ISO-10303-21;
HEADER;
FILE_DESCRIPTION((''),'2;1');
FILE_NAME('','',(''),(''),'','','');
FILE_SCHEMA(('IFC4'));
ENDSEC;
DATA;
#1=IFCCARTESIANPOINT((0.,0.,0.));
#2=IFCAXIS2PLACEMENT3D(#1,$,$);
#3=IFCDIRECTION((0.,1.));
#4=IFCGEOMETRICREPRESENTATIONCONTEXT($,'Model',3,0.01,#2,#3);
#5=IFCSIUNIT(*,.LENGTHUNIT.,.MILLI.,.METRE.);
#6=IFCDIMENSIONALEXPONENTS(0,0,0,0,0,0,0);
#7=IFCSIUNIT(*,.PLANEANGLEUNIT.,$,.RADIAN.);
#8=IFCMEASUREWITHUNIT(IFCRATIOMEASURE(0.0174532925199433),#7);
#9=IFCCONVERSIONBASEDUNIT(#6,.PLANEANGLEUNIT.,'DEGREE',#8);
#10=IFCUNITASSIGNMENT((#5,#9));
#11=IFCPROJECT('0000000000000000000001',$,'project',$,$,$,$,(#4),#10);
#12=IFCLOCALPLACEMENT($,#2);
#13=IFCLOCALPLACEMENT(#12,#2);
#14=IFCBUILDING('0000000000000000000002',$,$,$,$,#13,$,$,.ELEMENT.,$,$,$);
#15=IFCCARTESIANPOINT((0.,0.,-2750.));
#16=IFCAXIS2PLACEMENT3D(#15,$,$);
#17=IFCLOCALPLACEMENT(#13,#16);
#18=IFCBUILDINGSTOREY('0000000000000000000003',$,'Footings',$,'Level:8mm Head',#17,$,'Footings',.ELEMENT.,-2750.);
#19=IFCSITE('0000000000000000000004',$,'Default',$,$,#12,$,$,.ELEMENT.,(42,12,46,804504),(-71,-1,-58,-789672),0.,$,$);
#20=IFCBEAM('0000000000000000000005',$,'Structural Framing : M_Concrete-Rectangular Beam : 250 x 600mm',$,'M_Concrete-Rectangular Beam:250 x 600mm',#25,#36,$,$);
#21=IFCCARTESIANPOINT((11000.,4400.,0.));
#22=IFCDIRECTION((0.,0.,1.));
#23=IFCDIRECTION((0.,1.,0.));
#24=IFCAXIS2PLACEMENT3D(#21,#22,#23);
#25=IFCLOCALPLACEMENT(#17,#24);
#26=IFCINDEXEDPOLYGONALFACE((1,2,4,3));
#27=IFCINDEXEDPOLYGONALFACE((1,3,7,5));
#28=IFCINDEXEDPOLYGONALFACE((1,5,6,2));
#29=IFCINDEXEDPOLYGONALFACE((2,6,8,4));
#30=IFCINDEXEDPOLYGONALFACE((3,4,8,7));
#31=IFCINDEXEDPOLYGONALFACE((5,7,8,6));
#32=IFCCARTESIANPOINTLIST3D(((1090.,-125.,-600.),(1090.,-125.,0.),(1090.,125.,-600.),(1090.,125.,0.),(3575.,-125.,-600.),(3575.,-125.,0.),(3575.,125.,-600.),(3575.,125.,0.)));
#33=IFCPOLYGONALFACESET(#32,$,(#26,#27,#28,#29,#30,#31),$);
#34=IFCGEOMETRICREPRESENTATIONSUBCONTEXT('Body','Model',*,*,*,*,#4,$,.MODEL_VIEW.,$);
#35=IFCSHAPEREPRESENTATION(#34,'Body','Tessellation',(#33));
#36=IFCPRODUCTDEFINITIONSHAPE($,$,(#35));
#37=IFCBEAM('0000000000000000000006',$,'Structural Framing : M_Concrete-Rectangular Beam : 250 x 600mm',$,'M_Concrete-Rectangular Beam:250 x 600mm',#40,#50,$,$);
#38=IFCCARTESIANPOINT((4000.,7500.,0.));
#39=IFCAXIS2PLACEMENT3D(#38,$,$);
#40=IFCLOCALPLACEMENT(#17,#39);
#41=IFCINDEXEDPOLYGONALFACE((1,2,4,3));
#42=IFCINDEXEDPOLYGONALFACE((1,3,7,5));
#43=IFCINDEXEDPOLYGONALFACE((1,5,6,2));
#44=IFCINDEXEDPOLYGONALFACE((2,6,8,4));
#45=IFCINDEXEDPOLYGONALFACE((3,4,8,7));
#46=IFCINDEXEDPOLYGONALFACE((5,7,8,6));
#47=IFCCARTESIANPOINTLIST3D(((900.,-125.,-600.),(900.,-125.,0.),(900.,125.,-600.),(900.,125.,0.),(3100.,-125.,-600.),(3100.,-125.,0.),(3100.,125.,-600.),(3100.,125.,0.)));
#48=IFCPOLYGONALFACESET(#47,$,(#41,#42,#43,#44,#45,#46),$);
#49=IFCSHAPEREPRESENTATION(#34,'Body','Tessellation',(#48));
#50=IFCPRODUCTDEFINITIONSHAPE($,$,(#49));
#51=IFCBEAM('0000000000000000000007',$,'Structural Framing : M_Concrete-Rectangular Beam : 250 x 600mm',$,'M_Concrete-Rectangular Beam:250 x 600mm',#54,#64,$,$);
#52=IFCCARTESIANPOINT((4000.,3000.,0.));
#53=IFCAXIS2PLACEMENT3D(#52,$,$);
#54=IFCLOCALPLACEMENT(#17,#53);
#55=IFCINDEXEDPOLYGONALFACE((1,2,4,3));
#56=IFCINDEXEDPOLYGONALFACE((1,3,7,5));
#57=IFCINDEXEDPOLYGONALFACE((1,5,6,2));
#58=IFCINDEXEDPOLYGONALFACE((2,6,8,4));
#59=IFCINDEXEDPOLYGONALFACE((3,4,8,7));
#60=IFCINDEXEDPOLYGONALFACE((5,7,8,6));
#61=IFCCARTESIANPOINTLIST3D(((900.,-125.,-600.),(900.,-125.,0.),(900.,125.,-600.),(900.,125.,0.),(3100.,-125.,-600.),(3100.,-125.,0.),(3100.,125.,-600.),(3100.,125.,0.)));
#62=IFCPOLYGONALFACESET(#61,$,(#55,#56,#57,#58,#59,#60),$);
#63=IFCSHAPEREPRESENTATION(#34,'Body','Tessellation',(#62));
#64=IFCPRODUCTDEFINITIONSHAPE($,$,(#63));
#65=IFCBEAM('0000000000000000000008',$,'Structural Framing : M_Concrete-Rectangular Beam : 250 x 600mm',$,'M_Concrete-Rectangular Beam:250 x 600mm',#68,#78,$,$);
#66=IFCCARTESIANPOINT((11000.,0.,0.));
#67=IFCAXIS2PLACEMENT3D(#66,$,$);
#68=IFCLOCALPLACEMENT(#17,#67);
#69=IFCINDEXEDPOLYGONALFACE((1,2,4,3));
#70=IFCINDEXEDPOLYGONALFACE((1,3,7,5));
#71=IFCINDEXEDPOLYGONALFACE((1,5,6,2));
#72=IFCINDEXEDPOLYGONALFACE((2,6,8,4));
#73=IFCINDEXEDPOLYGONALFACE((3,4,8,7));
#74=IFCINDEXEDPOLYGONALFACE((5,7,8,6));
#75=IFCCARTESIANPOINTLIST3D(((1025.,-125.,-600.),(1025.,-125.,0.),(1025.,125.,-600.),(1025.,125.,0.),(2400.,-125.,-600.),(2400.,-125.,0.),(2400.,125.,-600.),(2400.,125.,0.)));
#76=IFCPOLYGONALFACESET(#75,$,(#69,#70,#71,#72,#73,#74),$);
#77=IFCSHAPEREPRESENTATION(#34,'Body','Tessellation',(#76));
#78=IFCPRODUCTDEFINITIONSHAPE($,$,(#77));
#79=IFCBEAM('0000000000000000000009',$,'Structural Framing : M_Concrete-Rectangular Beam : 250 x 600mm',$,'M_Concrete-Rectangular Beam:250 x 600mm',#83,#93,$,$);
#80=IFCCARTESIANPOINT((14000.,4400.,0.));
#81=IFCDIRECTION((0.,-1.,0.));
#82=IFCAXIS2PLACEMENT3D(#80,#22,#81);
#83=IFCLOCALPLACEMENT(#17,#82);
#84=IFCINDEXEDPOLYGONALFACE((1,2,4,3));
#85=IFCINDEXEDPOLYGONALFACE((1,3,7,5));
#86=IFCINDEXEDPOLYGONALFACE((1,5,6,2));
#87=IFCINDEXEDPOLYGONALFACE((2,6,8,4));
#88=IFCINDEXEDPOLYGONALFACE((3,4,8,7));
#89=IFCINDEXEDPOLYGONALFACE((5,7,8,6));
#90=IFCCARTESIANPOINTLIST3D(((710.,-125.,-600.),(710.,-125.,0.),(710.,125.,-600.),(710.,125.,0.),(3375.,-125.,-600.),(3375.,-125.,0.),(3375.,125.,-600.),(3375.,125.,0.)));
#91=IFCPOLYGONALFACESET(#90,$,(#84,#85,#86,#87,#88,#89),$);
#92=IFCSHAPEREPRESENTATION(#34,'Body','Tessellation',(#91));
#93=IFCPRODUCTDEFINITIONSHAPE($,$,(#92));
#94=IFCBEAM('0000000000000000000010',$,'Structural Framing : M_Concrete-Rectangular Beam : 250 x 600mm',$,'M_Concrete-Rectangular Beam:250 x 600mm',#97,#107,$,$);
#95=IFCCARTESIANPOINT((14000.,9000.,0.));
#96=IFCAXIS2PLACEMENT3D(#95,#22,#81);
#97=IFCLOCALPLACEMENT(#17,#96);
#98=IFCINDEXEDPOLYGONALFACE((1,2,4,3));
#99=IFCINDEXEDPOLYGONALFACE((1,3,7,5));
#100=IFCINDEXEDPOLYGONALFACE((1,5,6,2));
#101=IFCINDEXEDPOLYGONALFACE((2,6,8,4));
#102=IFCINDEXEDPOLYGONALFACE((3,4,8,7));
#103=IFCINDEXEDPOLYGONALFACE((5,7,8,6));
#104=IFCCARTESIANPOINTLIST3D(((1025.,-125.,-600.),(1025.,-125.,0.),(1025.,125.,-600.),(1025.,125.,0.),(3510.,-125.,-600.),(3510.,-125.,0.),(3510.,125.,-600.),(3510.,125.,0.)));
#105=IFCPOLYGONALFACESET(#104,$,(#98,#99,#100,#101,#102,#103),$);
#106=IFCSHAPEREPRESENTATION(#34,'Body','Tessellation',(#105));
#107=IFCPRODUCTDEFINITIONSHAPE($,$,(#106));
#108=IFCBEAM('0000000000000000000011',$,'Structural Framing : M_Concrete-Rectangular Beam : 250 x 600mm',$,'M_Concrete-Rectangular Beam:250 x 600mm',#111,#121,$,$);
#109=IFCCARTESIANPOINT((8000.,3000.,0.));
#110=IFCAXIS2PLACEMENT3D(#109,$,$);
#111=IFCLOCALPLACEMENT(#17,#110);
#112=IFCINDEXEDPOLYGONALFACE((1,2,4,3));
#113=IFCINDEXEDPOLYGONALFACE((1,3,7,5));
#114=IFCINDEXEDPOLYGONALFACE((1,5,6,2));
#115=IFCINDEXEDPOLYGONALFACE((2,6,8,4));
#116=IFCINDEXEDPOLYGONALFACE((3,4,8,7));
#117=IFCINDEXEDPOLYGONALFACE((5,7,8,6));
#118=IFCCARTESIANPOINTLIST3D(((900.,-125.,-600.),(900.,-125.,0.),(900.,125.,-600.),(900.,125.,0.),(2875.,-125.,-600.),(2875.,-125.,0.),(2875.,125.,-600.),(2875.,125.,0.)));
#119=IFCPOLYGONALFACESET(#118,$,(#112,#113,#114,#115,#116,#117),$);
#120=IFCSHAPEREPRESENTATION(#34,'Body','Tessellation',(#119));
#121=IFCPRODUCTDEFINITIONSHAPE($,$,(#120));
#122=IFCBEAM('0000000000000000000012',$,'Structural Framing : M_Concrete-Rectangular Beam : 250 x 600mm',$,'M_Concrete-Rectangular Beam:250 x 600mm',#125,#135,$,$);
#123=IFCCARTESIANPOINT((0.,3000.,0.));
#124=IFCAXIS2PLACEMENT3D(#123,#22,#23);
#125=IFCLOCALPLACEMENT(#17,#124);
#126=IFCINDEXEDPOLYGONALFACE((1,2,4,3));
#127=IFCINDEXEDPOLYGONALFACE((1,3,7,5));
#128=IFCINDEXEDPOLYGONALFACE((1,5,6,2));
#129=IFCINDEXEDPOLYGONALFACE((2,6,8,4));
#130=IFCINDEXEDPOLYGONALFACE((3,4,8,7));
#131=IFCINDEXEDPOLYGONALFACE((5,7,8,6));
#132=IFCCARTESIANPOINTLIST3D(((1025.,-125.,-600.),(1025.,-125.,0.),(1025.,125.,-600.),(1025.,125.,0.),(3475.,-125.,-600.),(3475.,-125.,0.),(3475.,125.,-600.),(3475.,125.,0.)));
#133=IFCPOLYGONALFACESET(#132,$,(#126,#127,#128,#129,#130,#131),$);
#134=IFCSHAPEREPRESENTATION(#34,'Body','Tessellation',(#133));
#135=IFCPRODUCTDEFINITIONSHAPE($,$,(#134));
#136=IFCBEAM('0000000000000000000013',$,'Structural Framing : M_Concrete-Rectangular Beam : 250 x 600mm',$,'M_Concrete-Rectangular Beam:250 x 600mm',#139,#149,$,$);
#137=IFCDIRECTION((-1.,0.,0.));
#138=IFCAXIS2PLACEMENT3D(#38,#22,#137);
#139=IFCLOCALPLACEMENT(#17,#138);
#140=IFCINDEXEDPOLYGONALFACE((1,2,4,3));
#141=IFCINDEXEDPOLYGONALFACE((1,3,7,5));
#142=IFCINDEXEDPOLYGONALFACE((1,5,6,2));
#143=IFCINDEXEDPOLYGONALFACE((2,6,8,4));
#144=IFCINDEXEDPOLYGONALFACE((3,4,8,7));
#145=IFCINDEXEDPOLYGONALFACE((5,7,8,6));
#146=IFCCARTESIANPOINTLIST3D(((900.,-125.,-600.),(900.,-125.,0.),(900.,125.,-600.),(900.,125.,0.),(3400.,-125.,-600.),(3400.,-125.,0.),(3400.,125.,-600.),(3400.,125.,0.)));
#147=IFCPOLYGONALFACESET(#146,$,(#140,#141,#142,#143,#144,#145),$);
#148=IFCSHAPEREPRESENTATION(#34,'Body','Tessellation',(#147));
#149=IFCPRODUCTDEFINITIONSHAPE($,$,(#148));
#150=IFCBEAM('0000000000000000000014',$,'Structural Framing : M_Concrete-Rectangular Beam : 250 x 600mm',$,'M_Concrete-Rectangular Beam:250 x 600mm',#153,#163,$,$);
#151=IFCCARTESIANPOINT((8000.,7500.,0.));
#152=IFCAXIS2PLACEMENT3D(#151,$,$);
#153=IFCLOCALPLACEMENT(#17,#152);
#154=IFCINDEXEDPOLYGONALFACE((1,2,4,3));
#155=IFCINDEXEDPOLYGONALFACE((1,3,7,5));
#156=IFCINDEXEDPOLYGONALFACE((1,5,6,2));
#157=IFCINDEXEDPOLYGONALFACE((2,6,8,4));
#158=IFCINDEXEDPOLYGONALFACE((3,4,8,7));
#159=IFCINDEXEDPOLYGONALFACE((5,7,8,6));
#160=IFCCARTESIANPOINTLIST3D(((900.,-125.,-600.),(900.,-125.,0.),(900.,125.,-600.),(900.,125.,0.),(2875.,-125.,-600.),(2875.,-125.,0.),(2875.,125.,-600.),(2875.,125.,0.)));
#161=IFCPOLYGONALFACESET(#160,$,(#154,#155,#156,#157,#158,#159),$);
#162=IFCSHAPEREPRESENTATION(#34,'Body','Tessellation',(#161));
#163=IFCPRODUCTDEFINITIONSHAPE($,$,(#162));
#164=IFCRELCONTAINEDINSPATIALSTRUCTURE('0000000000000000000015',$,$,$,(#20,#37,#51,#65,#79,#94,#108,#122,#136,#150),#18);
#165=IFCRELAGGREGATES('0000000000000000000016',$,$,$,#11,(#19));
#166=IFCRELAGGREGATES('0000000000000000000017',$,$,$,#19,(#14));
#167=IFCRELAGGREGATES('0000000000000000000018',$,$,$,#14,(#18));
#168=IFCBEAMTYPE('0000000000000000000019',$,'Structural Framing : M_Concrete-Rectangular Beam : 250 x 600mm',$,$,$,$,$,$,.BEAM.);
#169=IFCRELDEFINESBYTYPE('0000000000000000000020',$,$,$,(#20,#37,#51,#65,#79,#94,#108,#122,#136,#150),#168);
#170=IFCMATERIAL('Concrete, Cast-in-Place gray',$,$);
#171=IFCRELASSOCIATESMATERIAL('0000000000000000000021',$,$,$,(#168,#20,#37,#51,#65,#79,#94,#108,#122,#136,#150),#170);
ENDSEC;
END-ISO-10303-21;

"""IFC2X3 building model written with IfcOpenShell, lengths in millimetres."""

from ifc_helpers import new_model, entity, si_unit, converted_unit, direction, frame, frame_2d, origin, origin_2d_with_axis, place, context, subcontext, project, spatial, rectangle, extrude, material, type_object, element, save


model = new_model("IFC2X3")

# Units and contexts
model_context = context("Model", 3, precision=0.01, world=origin(), true_north=direction((0.0, 1.0)))
body_context = subcontext(model_context, "Body", "Model", "MODEL_VIEW")
ifc_project = project(units=[si_unit("LENGTHUNIT", "METRE", prefix="MILLI"), converted_unit("PLANEANGLEUNIT", "DEGREE", entity("IfcRatioMeasure", 0.0174532925199433), si_unit("PLANEANGLEUNIT", "RADIAN"), dimensions=[0, 0, 0, 0, 0, 0, 0])], contexts=[model_context])

# Site, building, storey
site_placement = place(None, origin())
site = spatial("IfcSite", under=ifc_project, at=site_placement, Name="Default", CompositionType="ELEMENT", RefLatitude=(42, 12, 46, 804504), RefLongitude=(-71, -1, -58, -789672), RefElevation=0.0)
building_placement = place(site_placement, origin())
building = spatial("IfcBuilding", under=site, at=building_placement, CompositionType="ELEMENT")
storey_placement = place(building_placement, frame((0.0, 0.0, -2750.0)))
storey = spatial("IfcBuildingStorey", under=building, at=storey_placement, Name="Footings", ObjectType="Level:8mm Head", LongName="Footings", CompositionType="ELEMENT", Elevation=-2750.0)

# Beams
ifc_material = material(Name="Concrete, Cast-in-Place gray")
beam_type = type_object("IfcBeamType", Name="Structural Framing : M_Concrete-Rectangular Beam : 250 x 600mm", PredefinedType="BEAM", material=ifc_material)
beam_1_placement = place(storey_placement, frame((11000.0, 4400.0, 0.0), z_axis=(0.0, 0.0, 1.0), x_axis=(0.0, 1.0, 0.0)))
element("IfcBeam", 1, at=beam_1_placement, inside=storey, type_object=beam_type, material=ifc_material, Name="Structural Framing : M_Concrete-Rectangular Beam : 250 x 600mm", ObjectType="M_Concrete-Rectangular Beam:250 x 600mm", context=body_context, shape_type="SweptSolid", body=[
    extrude(rectangle(XDim=600.0, YDim=250.0, at=frame_2d((0.0, 0.0), x_axis=(1.0, 0.0))), frame((1090.0, 0.0, -300.0), z_axis=(1.0, 0.0, 0.0), x_axis=(0.0, 0.0, -1.0)), (0.0, 0.0, 1.0), 2485.0),
])
beam_2_placement = place(storey_placement, frame((4000.0, 7500.0, 0.0)))
element("IfcBeam", 2, at=beam_2_placement, inside=storey, type_object=beam_type, material=ifc_material, Name="Structural Framing : M_Concrete-Rectangular Beam : 250 x 600mm", ObjectType="M_Concrete-Rectangular Beam:250 x 600mm", context=body_context, shape_type="SweptSolid", body=[
    extrude(rectangle(XDim=600.0, YDim=250.0, at=frame_2d((0.0, 0.0), x_axis=(1.0, 0.0))), frame((900.0, 0.0, -300.0), z_axis=(1.0, 0.0, 0.0), x_axis=(0.0, 0.0, -1.0)), (0.0, 0.0, 1.0), 2200.0),
])
beam_3_placement = place(storey_placement, frame((4000.0, 3000.0, 0.0)))
element("IfcBeam", 3, at=beam_3_placement, inside=storey, type_object=beam_type, material=ifc_material, Name="Structural Framing : M_Concrete-Rectangular Beam : 250 x 600mm", ObjectType="M_Concrete-Rectangular Beam:250 x 600mm", context=body_context, shape_type="SweptSolid", body=[
    extrude(rectangle(XDim=600.0, YDim=250.0, at=frame_2d((0.0, 0.0), x_axis=(1.0, 0.0))), frame((900.0, 0.0, -300.0), z_axis=(1.0, 0.0, 0.0), x_axis=(0.0, 0.0, -1.0)), (0.0, 0.0, 1.0), 2200.0),
])
beam_4_placement = place(storey_placement, frame((11000.0, 0.0, 0.0)))
element("IfcBeam", 4, at=beam_4_placement, inside=storey, type_object=beam_type, material=ifc_material, Name="Structural Framing : M_Concrete-Rectangular Beam : 250 x 600mm", ObjectType="M_Concrete-Rectangular Beam:250 x 600mm", context=body_context, shape_type="SweptSolid", body=[
    extrude(rectangle(XDim=600.0, YDim=250.0, at=frame_2d((0.0, 0.0), x_axis=(1.0, 0.0))), frame((1025.0, 0.0, -300.0), z_axis=(1.0, 0.0, 0.0), x_axis=(0.0, 0.0, -1.0)), (0.0, 0.0, 1.0), 1375.0),
])
beam_5_placement = place(storey_placement, frame((14000.0, 4400.0, 0.0), z_axis=(0.0, 0.0, 1.0), x_axis=(0.0, -1.0, 0.0)))
element("IfcBeam", 5, at=beam_5_placement, inside=storey, type_object=beam_type, material=ifc_material, Name="Structural Framing : M_Concrete-Rectangular Beam : 250 x 600mm", ObjectType="M_Concrete-Rectangular Beam:250 x 600mm", context=body_context, shape_type="SweptSolid", body=[
    extrude(rectangle(XDim=600.0, YDim=250.0, at=frame_2d((0.0, 0.0), x_axis=(1.0, 0.0))), frame((710.0, 0.0, -300.0), z_axis=(1.0, 0.0, 0.0), x_axis=(0.0, 0.0, -1.0)), (0.0, 0.0, 1.0), 2665.0),
])
beam_6_placement = place(storey_placement, frame((14000.0, 9000.0, 0.0), z_axis=(0.0, 0.0, 1.0), x_axis=(0.0, -1.0, 0.0)))
element("IfcBeam", 6, at=beam_6_placement, inside=storey, type_object=beam_type, material=ifc_material, Name="Structural Framing : M_Concrete-Rectangular Beam : 250 x 600mm", ObjectType="M_Concrete-Rectangular Beam:250 x 600mm", context=body_context, shape_type="SweptSolid", body=[
    extrude(rectangle(XDim=600.0, YDim=250.0, at=frame_2d((0.0, 0.0), x_axis=(1.0, 0.0))), frame((1025.0, 0.0, -300.0), z_axis=(1.0, 0.0, 0.0), x_axis=(0.0, 0.0, -1.0)), (0.0, 0.0, 1.0), 2485.0),
])
beam_7_placement = place(storey_placement, frame((8000.0, 3000.0, 0.0)))
element("IfcBeam", 7, at=beam_7_placement, inside=storey, type_object=beam_type, material=ifc_material, Name="Structural Framing : M_Concrete-Rectangular Beam : 250 x 600mm", ObjectType="M_Concrete-Rectangular Beam:250 x 600mm", context=body_context, shape_type="SweptSolid", body=[
    extrude(rectangle(XDim=600.0, YDim=250.0, at=frame_2d((0.0, 0.0), x_axis=(1.0, 0.0))), frame((900.0, 0.0, -300.0), z_axis=(1.0, 0.0, 0.0), x_axis=(0.0, 0.0, -1.0)), (0.0, 0.0, 1.0), 1975.0),
])
beam_8_placement = place(storey_placement, frame((0.0, 3000.0, 0.0), z_axis=(0.0, 0.0, 1.0), x_axis=(0.0, 1.0, 0.0)))
element("IfcBeam", 8, at=beam_8_placement, inside=storey, type_object=beam_type, material=ifc_material, Name="Structural Framing : M_Concrete-Rectangular Beam : 250 x 600mm", ObjectType="M_Concrete-Rectangular Beam:250 x 600mm", context=body_context, shape_type="SweptSolid", body=[
    extrude(rectangle(XDim=600.0, YDim=250.0, at=origin_2d_with_axis()), frame((1025.0, 0.0, -300.0), z_axis=(1.0, 0.0, 0.0), x_axis=(0.0, 0.0, -1.0)), (0.0, 0.0, 1.0), 2450.0),
])
beam_9_placement = place(storey_placement, frame((4000.0, 7500.0, 0.0), z_axis=(0.0, 0.0, 1.0), x_axis=(-1.0, 0.0, 0.0)))
element("IfcBeam", 9, at=beam_9_placement, inside=storey, type_object=beam_type, material=ifc_material, Name="Structural Framing : M_Concrete-Rectangular Beam : 250 x 600mm", ObjectType="M_Concrete-Rectangular Beam:250 x 600mm", context=body_context, shape_type="SweptSolid", body=[
    extrude(rectangle(XDim=600.0, YDim=250.0, at=frame_2d((0.0, 0.0), x_axis=(1.0, 0.0))), frame((900.0, 0.0, -300.0), z_axis=(1.0, 0.0, 0.0), x_axis=(0.0, 0.0, -1.0)), (0.0, 0.0, 1.0), 2500.0),
])
beam_10_placement = place(storey_placement, frame((8000.0, 7500.0, 0.0)))
element("IfcBeam", 10, at=beam_10_placement, inside=storey, type_object=beam_type, material=ifc_material, Name="Structural Framing : M_Concrete-Rectangular Beam : 250 x 600mm", ObjectType="M_Concrete-Rectangular Beam:250 x 600mm", context=body_context, shape_type="SweptSolid", body=[
    extrude(rectangle(XDim=600.0, YDim=250.0, at=frame_2d((0.0, 0.0), x_axis=(1.0, 0.0))), frame((900.0, 0.0, -300.0), z_axis=(1.0, 0.0, 0.0), x_axis=(0.0, 0.0, -1.0)), (0.0, 0.0, 1.0), 1975.0),
])

save(model, "model.ifc")
